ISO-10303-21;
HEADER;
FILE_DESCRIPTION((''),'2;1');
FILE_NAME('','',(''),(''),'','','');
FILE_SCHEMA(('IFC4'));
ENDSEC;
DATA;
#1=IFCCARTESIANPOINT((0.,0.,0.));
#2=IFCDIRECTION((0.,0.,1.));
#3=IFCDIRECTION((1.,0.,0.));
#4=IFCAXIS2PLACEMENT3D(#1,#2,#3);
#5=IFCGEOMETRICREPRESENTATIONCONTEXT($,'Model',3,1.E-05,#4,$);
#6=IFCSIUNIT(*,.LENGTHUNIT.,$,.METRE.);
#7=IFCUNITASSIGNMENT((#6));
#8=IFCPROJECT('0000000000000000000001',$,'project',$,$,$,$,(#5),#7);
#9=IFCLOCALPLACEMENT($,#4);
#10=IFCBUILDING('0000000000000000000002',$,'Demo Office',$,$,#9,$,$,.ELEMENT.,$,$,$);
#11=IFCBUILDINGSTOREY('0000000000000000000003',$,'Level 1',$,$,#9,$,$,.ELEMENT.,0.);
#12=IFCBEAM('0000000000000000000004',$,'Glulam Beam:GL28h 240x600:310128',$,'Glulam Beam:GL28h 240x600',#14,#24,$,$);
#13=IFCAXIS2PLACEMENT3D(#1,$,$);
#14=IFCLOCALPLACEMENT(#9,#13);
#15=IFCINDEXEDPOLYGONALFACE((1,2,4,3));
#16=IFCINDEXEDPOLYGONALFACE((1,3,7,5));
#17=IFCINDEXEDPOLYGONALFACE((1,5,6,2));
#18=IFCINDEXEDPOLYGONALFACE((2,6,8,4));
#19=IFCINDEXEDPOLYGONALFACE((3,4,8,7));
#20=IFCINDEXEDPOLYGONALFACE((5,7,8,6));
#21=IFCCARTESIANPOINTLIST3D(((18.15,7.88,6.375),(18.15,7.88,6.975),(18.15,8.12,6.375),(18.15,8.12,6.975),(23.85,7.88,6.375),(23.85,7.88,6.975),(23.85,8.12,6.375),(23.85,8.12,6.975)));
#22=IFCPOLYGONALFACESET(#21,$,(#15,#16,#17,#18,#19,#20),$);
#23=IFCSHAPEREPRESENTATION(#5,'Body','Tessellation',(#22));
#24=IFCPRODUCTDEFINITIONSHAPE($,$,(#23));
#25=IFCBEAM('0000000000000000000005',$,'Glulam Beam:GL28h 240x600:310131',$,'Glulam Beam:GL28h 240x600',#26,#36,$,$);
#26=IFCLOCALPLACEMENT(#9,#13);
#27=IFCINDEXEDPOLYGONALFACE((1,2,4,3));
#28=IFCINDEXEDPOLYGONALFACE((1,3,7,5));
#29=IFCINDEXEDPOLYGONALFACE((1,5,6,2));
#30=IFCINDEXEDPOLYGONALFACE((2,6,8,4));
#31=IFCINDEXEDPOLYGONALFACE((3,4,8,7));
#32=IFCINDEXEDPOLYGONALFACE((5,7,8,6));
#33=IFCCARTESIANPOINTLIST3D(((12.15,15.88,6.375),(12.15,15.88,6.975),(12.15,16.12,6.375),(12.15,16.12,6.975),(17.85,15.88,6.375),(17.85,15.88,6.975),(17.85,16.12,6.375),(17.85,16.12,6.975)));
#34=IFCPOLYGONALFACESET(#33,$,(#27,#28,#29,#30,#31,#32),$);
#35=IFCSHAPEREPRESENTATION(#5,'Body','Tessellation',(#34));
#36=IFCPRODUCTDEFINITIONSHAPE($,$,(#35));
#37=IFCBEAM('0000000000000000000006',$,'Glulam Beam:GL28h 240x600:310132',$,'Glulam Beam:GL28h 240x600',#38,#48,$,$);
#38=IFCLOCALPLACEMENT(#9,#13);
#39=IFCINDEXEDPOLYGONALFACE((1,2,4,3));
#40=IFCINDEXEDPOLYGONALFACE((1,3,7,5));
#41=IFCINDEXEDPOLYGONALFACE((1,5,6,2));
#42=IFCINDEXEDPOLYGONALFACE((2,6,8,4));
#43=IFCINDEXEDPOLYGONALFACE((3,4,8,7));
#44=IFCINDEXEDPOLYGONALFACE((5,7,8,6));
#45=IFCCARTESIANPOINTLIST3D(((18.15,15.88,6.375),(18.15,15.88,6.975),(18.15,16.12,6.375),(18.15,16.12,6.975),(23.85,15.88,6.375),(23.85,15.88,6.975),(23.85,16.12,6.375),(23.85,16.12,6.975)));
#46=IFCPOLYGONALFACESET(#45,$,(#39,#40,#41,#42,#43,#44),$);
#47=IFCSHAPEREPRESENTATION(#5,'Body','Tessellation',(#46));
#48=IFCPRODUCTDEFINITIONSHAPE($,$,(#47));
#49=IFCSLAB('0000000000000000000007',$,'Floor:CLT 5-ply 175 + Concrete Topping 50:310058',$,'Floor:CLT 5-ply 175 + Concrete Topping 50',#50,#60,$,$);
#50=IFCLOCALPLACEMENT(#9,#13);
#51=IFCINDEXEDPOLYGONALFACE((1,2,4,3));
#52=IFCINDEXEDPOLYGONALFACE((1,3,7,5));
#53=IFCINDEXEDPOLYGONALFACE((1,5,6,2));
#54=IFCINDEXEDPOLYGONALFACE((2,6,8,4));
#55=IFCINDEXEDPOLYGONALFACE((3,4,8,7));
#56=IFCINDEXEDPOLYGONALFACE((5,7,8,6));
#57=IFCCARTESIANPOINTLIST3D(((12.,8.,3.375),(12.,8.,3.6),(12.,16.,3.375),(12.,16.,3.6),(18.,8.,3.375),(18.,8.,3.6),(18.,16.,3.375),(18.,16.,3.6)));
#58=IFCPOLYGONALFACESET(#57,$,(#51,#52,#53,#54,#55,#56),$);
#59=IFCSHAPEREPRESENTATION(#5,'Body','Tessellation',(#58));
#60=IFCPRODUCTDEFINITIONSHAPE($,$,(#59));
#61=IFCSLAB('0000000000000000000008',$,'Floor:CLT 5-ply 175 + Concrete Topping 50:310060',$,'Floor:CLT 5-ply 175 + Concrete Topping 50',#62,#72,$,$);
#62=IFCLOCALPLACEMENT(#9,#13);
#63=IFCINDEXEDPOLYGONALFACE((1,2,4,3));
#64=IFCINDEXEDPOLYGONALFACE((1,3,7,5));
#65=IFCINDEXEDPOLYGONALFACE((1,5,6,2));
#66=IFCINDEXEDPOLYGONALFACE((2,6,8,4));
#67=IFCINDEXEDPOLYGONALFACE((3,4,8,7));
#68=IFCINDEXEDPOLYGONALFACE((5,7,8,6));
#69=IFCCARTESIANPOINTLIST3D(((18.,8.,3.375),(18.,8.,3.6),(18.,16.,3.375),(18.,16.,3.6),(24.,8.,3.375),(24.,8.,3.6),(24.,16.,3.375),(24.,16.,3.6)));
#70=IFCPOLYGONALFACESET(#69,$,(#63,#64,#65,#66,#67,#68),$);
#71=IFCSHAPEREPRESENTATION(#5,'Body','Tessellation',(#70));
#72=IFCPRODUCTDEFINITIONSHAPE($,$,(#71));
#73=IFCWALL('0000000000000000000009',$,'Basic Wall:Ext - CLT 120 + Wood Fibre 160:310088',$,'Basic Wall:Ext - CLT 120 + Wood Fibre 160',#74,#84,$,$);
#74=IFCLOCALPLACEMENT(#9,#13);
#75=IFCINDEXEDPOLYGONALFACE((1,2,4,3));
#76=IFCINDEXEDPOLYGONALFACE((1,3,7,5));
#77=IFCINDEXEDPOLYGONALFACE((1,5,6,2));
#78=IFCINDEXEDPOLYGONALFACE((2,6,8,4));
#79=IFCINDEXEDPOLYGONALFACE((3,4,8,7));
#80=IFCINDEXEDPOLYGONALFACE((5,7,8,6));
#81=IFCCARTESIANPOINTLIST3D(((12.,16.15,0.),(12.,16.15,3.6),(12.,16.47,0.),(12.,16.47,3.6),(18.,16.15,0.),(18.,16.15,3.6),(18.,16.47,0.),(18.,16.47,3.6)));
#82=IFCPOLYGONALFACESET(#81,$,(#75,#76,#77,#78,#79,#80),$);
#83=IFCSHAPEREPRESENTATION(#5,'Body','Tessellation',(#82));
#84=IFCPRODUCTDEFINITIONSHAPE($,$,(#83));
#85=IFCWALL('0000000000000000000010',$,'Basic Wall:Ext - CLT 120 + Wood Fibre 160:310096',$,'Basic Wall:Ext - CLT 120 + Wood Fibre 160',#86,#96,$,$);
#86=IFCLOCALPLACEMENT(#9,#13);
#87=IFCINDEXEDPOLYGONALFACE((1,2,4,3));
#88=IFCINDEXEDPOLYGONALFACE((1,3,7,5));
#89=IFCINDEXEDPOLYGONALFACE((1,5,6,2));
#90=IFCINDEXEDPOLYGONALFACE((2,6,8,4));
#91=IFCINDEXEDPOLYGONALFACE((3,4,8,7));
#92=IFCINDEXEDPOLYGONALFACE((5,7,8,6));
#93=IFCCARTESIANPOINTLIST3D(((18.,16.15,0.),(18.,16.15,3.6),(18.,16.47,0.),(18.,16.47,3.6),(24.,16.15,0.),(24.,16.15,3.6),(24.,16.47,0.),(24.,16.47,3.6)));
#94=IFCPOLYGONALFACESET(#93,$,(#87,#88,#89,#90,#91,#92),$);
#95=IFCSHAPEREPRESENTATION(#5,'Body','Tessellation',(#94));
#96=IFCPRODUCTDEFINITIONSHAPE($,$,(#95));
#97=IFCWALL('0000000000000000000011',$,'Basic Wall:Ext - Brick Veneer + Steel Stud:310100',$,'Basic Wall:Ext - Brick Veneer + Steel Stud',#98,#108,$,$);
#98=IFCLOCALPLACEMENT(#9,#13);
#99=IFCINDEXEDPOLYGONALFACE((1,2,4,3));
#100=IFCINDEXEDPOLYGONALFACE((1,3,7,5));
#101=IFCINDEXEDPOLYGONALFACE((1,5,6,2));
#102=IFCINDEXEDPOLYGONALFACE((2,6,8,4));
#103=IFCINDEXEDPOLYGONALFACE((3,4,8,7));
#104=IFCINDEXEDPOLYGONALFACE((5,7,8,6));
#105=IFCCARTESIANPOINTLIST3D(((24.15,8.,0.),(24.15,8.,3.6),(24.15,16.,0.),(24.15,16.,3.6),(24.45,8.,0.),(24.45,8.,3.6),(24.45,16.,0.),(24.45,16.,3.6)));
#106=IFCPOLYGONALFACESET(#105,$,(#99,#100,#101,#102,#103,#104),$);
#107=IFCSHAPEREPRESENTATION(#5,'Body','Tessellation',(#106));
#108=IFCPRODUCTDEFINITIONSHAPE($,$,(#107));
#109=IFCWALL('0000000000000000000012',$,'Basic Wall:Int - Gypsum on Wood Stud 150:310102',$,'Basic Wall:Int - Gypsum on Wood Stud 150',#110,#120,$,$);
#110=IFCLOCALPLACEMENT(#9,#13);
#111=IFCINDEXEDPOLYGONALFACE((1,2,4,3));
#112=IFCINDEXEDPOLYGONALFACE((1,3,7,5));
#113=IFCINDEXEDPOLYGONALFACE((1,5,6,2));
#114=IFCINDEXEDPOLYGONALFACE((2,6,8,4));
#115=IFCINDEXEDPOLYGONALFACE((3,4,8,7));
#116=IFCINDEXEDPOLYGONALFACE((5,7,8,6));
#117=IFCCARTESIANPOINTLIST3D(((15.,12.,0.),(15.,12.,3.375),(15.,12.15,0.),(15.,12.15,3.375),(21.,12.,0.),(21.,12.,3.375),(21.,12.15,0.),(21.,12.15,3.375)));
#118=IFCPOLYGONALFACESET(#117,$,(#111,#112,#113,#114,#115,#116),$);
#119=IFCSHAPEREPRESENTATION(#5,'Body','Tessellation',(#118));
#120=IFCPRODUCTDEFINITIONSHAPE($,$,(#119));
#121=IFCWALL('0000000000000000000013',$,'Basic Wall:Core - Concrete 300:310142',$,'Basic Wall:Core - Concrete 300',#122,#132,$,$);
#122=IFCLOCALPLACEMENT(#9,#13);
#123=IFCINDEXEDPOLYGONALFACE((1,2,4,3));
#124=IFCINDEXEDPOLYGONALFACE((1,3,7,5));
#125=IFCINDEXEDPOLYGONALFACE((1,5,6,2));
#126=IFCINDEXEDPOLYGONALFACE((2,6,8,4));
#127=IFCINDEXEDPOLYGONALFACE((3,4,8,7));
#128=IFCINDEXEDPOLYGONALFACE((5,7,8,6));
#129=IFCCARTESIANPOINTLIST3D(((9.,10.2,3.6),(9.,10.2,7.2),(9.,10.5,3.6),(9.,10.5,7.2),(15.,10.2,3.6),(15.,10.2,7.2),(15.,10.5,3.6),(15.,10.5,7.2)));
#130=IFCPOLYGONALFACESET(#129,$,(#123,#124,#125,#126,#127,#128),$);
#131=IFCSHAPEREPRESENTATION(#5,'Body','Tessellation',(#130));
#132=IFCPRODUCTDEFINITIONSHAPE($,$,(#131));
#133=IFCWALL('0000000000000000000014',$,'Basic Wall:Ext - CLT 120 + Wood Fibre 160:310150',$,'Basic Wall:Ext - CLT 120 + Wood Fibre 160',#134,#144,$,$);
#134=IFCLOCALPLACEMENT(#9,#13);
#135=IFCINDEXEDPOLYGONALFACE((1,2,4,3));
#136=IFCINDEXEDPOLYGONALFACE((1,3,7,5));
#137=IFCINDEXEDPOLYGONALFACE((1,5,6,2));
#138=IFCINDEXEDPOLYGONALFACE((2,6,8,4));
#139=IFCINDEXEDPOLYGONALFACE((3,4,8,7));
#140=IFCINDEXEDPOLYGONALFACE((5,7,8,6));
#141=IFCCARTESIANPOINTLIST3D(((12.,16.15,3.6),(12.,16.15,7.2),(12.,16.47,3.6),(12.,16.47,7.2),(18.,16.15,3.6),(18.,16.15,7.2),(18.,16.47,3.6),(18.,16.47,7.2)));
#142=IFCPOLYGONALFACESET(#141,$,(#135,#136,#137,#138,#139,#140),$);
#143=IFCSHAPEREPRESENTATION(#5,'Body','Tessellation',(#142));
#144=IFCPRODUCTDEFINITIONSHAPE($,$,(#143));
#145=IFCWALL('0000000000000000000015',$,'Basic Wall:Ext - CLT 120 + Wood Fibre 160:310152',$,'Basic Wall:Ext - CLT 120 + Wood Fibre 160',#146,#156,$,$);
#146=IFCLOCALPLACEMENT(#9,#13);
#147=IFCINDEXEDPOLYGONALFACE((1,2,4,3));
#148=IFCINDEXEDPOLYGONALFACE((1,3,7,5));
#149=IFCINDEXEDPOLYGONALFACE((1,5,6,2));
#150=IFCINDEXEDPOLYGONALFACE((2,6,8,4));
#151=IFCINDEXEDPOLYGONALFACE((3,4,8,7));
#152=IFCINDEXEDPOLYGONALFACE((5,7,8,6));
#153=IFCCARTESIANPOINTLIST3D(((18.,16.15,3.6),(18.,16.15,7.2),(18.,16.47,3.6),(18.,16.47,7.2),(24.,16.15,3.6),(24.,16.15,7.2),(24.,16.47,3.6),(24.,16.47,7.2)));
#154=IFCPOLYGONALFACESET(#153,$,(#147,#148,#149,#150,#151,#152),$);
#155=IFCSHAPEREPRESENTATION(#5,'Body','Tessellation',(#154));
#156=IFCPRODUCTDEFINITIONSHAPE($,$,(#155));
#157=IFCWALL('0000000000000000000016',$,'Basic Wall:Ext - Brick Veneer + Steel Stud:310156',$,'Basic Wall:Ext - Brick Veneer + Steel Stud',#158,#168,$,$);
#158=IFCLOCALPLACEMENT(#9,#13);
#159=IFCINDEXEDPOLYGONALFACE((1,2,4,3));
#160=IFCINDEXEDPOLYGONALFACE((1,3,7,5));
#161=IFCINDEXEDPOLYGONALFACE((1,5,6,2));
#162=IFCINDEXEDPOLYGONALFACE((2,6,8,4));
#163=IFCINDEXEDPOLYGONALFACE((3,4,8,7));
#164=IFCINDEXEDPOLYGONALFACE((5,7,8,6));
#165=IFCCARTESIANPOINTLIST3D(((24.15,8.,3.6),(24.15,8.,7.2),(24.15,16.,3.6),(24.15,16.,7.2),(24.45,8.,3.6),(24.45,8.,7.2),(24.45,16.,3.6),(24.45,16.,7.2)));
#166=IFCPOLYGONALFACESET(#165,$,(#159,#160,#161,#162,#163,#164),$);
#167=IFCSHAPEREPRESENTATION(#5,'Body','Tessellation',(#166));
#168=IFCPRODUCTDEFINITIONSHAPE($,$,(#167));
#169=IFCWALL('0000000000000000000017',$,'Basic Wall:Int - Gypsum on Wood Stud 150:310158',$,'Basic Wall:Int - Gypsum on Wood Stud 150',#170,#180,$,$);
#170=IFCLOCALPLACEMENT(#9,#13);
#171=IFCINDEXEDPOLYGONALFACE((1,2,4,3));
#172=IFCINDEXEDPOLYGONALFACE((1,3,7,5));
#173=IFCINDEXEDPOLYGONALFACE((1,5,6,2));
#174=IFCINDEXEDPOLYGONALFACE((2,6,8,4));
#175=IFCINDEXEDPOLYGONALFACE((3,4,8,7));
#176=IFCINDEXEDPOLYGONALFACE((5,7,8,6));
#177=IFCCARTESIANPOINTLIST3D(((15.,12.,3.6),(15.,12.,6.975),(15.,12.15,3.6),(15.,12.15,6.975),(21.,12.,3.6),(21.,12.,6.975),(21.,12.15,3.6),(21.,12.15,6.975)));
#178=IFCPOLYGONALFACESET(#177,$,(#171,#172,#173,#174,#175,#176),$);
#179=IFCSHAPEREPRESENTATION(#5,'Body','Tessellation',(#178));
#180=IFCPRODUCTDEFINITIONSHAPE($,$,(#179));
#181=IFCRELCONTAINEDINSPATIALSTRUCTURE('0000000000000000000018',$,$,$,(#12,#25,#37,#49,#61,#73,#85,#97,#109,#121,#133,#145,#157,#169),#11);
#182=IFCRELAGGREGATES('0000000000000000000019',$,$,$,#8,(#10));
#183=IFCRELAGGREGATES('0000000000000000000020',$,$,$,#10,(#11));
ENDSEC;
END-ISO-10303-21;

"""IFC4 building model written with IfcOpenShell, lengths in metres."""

from ifc_helpers import new_model, si_unit, frame, origin_with_axes, origin_2d, place, context, project, spatial, rectangle, extrude, element, save


model = new_model("IFC4")

# Units and contexts
model_context = context("Model", 3, precision=1e-05, world=origin_with_axes())
ifc_project = project(units=[si_unit("LENGTHUNIT", "METRE")], contexts=[model_context])

# Building, storey
placement = place(None, origin_with_axes())
building = spatial("IfcBuilding", under=ifc_project, at=placement, Name="Demo Office", CompositionType="ELEMENT")
storey = spatial("IfcBuildingStorey", under=building, at=placement, Name="Level 1", CompositionType="ELEMENT", Elevation=0.0)

# Beams
for number, where, name in (
    (1, (21.0, 8.0, 6.375), "Glulam Beam:GL28h 240x600:310128"),
    (2, (15.0, 16.0, 6.375), "Glulam Beam:GL28h 240x600:310131"),
    (3, (21.0, 16.0, 6.375), "Glulam Beam:GL28h 240x600:310132"),
):
    element("IfcBeam", number, at=place(placement, frame(where)), inside=storey, Name=name, ObjectType="Glulam Beam:GL28h 240x600", context=model_context, shape_type="SweptSolid", body=[
        extrude(rectangle(XDim=5.7, YDim=0.24, at=origin_2d()), origin_with_axes(), (0.0, 0.0, 1.0), 0.6),
    ])

# Slabs
for number, where, name in (
    (4, (15.0, 12.0, 3.375), "Floor:CLT 5-ply 175 + Concrete Topping 50:310058"),
    (5, (21.0, 12.0, 3.375), "Floor:CLT 5-ply 175 + Concrete Topping 50:310060"),
):
    element("IfcSlab", number, at=place(placement, frame(where)), inside=storey, Name=name, ObjectType="Floor:CLT 5-ply 175 + Concrete Topping 50", context=model_context, shape_type="SweptSolid", body=[
        extrude(rectangle(XDim=6.0, YDim=8.0, at=origin_2d()), origin_with_axes(), (0.0, 0.0, 1.0), 0.225),
    ])

# Walls
for number, where, name in (
    (6, (15.0, 16.31, 0.0), "Basic Wall:Ext - CLT 120 + Wood Fibre 160:310088"),
    (7, (21.0, 16.31, 0.0), "Basic Wall:Ext - CLT 120 + Wood Fibre 160:310096"),
):
    element("IfcWall", number, at=place(placement, frame(where)), inside=storey, Name=name, ObjectType="Basic Wall:Ext - CLT 120 + Wood Fibre 160", context=model_context, shape_type="SweptSolid", body=[
        extrude(rectangle(XDim=6.0, YDim=0.32, at=origin_2d()), origin_with_axes(), (0.0, 0.0, 1.0), 3.6),
    ])
wall_1_placement = place(placement, frame((24.3, 12.0, 0.0)))
element("IfcWall", 8, at=wall_1_placement, inside=storey, Name="Basic Wall:Ext - Brick Veneer + Steel Stud:310100", ObjectType="Basic Wall:Ext - Brick Veneer + Steel Stud", context=model_context, shape_type="SweptSolid", body=[
    extrude(rectangle(XDim=0.3, YDim=8.0, at=origin_2d()), origin_with_axes(), (0.0, 0.0, 1.0), 3.6),
])
wall_2_placement = place(placement, frame((18.0, 12.075, 0.0)))
element("IfcWall", 9, at=wall_2_placement, inside=storey, Name="Basic Wall:Int - Gypsum on Wood Stud 150:310102", ObjectType="Basic Wall:Int - Gypsum on Wood Stud 150", context=model_context, shape_type="SweptSolid", body=[
    extrude(rectangle(XDim=6.0, YDim=0.15, at=origin_2d()), origin_with_axes(), (0.0, 0.0, 1.0), 3.375),
])
wall_3_placement = place(placement, frame((12.0, 10.35, 3.6)))
element("IfcWall", 10, at=wall_3_placement, inside=storey, Name="Basic Wall:Core - Concrete 300:310142", ObjectType="Basic Wall:Core - Concrete 300", context=model_context, shape_type="SweptSolid", body=[
    extrude(rectangle(XDim=6.0, YDim=0.3, at=origin_2d()), origin_with_axes(), (0.0, 0.0, 1.0), 3.6),
])
for number, where, name in (
    (11, (15.0, 16.31, 3.6), "Basic Wall:Ext - CLT 120 + Wood Fibre 160:310150"),
    (12, (21.0, 16.31, 3.6), "Basic Wall:Ext - CLT 120 + Wood Fibre 160:310152"),
):
    element("IfcWall", number, at=place(placement, frame(where)), inside=storey, Name=name, ObjectType="Basic Wall:Ext - CLT 120 + Wood Fibre 160", context=model_context, shape_type="SweptSolid", body=[
        extrude(rectangle(XDim=6.0, YDim=0.32, at=origin_2d()), origin_with_axes(), (0.0, 0.0, 1.0), 3.6),
    ])
wall_4_placement = place(placement, frame((24.3, 12.0, 3.6)))
element("IfcWall", 13, at=wall_4_placement, inside=storey, Name="Basic Wall:Ext - Brick Veneer + Steel Stud:310156", ObjectType="Basic Wall:Ext - Brick Veneer + Steel Stud", context=model_context, shape_type="SweptSolid", body=[
    extrude(rectangle(XDim=0.3, YDim=8.0, at=origin_2d()), origin_with_axes(), (0.0, 0.0, 1.0), 3.6),
])
wall_5_placement = place(placement, frame((18.0, 12.075, 3.6)))
element("IfcWall", 14, at=wall_5_placement, inside=storey, Name="Basic Wall:Int - Gypsum on Wood Stud 150:310158", ObjectType="Basic Wall:Int - Gypsum on Wood Stud 150", context=model_context, shape_type="SweptSolid", body=[
    extrude(rectangle(XDim=6.0, YDim=0.15, at=origin_2d()), origin_with_axes(), (0.0, 0.0, 1.0), 3.375),
])

save(model, "model.ifc")
